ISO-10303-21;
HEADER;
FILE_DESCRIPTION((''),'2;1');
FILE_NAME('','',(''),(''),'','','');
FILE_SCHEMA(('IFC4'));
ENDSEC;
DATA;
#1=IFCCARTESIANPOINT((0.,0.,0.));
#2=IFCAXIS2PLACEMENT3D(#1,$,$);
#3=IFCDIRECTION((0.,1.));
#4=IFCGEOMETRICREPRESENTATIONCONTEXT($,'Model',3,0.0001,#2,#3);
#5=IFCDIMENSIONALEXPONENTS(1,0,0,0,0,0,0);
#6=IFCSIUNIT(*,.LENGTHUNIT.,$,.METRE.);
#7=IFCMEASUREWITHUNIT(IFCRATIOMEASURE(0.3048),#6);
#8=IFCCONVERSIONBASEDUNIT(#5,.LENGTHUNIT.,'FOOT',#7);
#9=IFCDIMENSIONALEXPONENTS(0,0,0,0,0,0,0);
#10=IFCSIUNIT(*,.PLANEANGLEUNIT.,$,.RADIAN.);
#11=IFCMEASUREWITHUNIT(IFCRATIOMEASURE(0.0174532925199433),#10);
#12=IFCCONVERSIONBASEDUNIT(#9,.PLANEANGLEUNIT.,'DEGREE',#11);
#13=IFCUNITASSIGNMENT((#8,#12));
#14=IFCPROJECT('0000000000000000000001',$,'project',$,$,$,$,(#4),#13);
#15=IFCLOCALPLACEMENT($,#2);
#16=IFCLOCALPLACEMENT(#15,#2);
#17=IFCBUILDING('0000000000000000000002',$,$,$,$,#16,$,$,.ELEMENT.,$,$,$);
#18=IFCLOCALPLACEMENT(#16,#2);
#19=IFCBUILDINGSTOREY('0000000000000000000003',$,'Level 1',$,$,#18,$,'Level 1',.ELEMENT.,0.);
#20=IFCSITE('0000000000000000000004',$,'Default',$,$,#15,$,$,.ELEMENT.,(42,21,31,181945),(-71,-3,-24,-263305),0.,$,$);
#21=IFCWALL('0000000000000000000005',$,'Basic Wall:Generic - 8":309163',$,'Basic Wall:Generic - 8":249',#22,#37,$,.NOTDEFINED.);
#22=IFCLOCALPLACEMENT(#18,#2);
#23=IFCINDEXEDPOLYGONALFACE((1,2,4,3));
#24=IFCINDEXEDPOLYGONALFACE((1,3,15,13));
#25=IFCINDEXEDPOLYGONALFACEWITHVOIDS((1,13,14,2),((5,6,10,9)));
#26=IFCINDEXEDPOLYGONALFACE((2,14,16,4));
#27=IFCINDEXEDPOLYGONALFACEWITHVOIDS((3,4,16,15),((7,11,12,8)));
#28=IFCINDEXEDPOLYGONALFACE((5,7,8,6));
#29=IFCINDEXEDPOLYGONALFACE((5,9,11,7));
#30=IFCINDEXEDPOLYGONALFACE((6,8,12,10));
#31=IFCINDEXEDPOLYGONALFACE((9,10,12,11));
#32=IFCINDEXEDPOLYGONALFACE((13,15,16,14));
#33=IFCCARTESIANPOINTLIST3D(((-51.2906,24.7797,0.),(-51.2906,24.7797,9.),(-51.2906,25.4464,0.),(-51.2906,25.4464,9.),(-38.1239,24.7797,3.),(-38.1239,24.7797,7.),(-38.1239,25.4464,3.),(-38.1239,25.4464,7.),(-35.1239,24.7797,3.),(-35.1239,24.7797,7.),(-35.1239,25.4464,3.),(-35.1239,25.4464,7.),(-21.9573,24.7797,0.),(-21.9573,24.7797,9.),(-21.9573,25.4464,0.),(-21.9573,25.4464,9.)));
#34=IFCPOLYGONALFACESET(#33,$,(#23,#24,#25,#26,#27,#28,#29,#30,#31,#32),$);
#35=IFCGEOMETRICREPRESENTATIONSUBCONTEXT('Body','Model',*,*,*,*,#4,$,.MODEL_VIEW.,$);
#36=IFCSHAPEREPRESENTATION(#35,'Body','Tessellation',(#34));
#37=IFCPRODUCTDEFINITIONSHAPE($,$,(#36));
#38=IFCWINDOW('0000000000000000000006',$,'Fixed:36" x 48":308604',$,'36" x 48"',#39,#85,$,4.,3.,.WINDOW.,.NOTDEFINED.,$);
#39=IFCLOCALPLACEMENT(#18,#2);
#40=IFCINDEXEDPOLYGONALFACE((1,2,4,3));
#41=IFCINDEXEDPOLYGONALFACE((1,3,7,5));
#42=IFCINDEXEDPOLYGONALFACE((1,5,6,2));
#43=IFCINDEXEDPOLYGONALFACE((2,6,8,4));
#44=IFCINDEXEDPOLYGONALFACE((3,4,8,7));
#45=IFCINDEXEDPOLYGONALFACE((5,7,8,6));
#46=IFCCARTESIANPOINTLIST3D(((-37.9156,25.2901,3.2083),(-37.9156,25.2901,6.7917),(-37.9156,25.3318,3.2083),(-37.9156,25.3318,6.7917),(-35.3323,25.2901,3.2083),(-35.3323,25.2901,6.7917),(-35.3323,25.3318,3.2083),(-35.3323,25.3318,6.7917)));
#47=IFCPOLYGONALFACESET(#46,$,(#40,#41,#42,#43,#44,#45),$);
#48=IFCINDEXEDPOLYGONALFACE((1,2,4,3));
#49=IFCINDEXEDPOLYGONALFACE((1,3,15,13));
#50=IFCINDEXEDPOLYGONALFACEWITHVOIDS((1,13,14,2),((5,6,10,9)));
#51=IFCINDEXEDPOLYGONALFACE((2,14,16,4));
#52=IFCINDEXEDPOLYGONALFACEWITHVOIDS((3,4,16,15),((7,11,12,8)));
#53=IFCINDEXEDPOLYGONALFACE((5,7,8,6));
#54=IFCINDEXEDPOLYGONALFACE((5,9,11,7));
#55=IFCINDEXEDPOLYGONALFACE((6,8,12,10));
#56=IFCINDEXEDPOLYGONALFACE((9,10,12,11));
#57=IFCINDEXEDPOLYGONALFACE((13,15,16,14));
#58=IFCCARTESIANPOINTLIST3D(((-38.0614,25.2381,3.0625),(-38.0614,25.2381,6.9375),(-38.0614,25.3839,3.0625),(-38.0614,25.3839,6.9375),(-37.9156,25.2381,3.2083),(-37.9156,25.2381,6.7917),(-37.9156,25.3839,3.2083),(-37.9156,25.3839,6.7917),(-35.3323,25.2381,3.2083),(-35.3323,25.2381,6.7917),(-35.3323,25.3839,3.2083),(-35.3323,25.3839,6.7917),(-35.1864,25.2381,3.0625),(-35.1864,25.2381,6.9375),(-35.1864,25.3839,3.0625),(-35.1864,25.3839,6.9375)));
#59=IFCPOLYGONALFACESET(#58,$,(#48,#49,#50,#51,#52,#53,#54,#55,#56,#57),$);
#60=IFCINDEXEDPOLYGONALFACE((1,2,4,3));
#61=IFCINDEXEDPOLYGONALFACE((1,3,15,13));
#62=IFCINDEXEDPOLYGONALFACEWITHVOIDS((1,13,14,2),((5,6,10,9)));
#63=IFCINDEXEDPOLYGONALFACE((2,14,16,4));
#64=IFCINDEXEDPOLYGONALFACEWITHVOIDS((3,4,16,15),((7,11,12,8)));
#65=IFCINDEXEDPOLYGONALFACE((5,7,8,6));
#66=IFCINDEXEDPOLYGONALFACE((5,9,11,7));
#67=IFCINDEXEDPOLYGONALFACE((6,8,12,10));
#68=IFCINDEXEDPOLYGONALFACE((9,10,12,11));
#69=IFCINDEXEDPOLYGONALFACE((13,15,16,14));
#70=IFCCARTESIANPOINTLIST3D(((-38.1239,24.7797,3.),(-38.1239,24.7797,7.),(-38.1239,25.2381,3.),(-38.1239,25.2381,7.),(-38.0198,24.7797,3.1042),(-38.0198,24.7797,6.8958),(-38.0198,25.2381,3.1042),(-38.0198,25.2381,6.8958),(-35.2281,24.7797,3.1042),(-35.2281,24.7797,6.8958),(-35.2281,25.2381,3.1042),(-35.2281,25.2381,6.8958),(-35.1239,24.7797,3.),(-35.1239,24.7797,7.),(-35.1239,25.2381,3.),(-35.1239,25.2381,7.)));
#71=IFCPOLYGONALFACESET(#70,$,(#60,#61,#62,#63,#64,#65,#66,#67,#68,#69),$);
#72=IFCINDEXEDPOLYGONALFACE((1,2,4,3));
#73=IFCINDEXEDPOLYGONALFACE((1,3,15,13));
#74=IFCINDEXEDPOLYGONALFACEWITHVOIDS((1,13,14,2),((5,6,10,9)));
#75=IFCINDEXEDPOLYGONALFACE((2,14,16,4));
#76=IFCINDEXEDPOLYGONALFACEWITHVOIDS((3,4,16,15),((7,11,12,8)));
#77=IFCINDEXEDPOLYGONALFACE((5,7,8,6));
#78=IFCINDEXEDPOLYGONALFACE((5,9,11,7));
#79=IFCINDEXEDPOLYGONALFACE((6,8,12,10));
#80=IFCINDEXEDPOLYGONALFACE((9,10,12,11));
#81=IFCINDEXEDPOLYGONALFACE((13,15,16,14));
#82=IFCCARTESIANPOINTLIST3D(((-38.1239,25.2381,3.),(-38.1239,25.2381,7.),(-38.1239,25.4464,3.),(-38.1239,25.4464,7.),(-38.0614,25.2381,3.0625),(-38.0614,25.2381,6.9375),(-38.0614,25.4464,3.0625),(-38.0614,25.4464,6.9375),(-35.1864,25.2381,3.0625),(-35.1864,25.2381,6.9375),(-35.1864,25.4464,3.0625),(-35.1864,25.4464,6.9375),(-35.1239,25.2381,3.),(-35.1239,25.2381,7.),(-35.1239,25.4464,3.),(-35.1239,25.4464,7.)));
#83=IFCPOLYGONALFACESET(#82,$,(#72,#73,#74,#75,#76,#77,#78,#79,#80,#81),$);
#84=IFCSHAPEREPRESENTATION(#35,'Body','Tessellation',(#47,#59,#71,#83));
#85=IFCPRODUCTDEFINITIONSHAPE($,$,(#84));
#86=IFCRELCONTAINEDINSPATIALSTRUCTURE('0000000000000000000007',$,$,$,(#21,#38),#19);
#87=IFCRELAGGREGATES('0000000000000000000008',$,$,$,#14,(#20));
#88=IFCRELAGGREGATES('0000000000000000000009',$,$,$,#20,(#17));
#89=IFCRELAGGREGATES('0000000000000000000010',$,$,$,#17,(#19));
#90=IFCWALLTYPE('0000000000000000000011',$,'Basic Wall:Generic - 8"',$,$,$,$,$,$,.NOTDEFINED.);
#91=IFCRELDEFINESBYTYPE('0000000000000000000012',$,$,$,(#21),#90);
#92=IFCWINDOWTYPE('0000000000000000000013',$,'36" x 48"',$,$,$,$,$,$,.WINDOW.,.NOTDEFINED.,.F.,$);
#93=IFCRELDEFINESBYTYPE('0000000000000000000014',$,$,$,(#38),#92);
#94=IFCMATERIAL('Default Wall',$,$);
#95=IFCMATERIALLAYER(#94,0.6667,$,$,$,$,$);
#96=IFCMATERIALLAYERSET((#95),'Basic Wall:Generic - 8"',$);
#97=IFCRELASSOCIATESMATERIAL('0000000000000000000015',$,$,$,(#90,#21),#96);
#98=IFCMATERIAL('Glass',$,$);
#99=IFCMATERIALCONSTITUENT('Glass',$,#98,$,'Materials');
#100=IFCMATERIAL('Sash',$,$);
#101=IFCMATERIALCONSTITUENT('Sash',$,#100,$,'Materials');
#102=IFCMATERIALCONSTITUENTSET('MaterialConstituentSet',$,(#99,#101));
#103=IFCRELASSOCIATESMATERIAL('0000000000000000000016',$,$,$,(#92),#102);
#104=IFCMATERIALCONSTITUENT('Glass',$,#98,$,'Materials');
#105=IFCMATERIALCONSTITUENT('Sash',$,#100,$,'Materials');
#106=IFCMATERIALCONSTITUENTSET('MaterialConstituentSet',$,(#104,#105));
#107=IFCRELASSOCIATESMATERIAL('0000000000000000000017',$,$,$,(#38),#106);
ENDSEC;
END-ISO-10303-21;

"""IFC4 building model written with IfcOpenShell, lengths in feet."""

from ifc_helpers import new_model, entity, si_unit, converted_unit, direction, frame, frame_2d, origin, place, context, subcontext, project, spatial, polyline, rectangle, outline, extrude, clip, bounded_halfspace, source, transform, mapped, material, layer, layer_set, layer_usage, constituent, constituent_set, type_object, type_shapes, element, fill, save


model = new_model("IFC4")

# Units and contexts
model_context = context("Model", 3, precision=0.0001, world=origin(), true_north=direction((0.0, 1.0)))
body_context = subcontext(model_context, "Body", "Model", "MODEL_VIEW")
ifc_project = project(units=[converted_unit("LENGTHUNIT", "FOOT", entity("IfcRatioMeasure", 0.3048), si_unit("LENGTHUNIT", "METRE"), dimensions=[1, 0, 0, 0, 0, 0, 0]), converted_unit("PLANEANGLEUNIT", "DEGREE", entity("IfcRatioMeasure", 0.0174532925199433), si_unit("PLANEANGLEUNIT", "RADIAN"), dimensions=[0, 0, 0, 0, 0, 0, 0])], contexts=[model_context])

# Site, building, storey
site_placement = place(None, origin())
site = spatial("IfcSite", under=ifc_project, at=site_placement, Name="Default", CompositionType="ELEMENT", RefLatitude=(42, 21, 31, 181945), RefLongitude=(-71, -3, -24, -263305), RefElevation=0.0)
building_placement = place(site_placement, origin())
building = spatial("IfcBuilding", under=site, at=building_placement, CompositionType="ELEMENT")
storey_placement = place(building_placement, origin())
storey = spatial("IfcBuildingStorey", under=building, at=storey_placement, Name="Level 1", LongName="Level 1", CompositionType="ELEMENT", Elevation=0.0)

# Shared definitions
ifc_material_1 = material(Name="Default Wall")
ifc_layer = layer(ifc_material_1, 0.6667)
ifc_layer_set = layer_set([ifc_layer], Name="Basic Wall:Generic - 8\"")
wall_type = type_object("IfcWallType", Name="Basic Wall:Generic - 8\"", PredefinedType="NOTDEFINED", material=ifc_layer_set)
ifc_material_2 = material(Name="Glass")
ifc_material_3 = material(Name="Sash")
ifc_constituent_1 = constituent(ifc_material_2, Name="Glass", Category="Materials")
ifc_constituent_2 = constituent(ifc_material_3, Name="Sash", Category="Materials")
ifc_constituent_set_1 = constituent_set(constituents=[ifc_constituent_1, ifc_constituent_2], Name="MaterialConstituentSet")
window_type_1 = type_object("IfcWindowType", Name="36\" x 48\"", ParameterTakesPrecedence=False, PartitioningType="NOTDEFINED", PredefinedType="WINDOW", material=ifc_constituent_set_1)
shared_shape_1 = source(origin(), body_context, "Body", "SweptSolid", [
    extrude(rectangle(XDim=0.0417, YDim=2.5833, at=frame_2d((0.0, 0.0), x_axis=(1.0, 0.0))), frame((1.5, 0.5312, 0.2083), z_axis=(0.0, 0.0, 1.0), x_axis=(0.0, 1.0, 0.0)), (0.0, 0.0, 1.0), 3.5833),
    extrude(outline(polyline([(-1.4375, -1.9375), (1.4375, -1.9375), (1.4375, 1.9375), (-1.4375, 1.9375), (-1.4375, -1.9375)]), holes=[polyline([(-1.2917, -1.7917), (-1.2917, 1.7917), (1.2917, 1.7917), (1.2917, -1.7917), (-1.2917, -1.7917)])]), frame((1.5, 0.4583, 2.0), z_axis=(0.0, 1.0, 0.0), x_axis=(1.0, 0.0, 0.0)), (0.0, 0.0, 1.0), 0.1458),
    extrude(outline(polyline([(-1.5, -2.0), (1.5, -2.0), (1.5, 2.0), (-1.5, 2.0), (-1.5, -2.0)]), holes=[polyline([(-1.3958, -1.8958), (-1.3958, 1.8958), (1.3958, 1.8958), (1.3958, -1.8958), (-1.3958, -1.8958)])]), frame((1.5, 0.0, 2.0), z_axis=(0.0, 1.0, 0.0), x_axis=(1.0, 0.0, 0.0)), (0.0, 0.0, 1.0), 0.4583),
    extrude(outline(polyline([(-2.0, -1.5), (2.0, -1.5), (2.0, 1.5), (-2.0, 1.5), (-2.0, -1.5)]), holes=[polyline([(-1.9375, -1.4375), (-1.9375, 1.4375), (1.9375, 1.4375), (1.9375, -1.4375), (-1.9375, -1.4375)])]), frame((1.5, 0.4583, 2.0), z_axis=(0.0, 1.0, 0.0), x_axis=(0.0, 0.0, -1.0)), (0.0, 0.0, 1.0), 0.2083),
])
type_shapes(window_type_1, [shared_shape_1])

# Wall, opening, window
ifc_layer_usage_1 = layer_usage(ifc_layer_set, "AXIS2", "NEGATIVE", 0.3333)
wall_1_placement = place(storey_placement, frame((-51.2906, 25.1131, 0.0)))
wall_1 = element("IfcWall", 1, at=wall_1_placement, inside=storey, type_object=wall_type, material=ifc_layer_usage_1, Name="Basic Wall:Generic - 8\":309163", ObjectType="Basic Wall:Generic - 8\":249", PredefinedType="NOTDEFINED", context=body_context, shape_type="Clipping", body=[
    clip(extrude(rectangle(XDim=29.3333, YDim=0.6667, at=frame_2d((14.6667, 0.0), x_axis=(-1.0, 0.0))), origin(), (0.0, 0.0, 1.0), 9.0), bounded_halfspace(frame((0.0, -0.3333, 9.0), z_axis=(0.0, 0.0, -1.0), x_axis=(1.0, 0.0, 0.0)), True, frame((0.0, -0.3333, 9.0)), polyline([(0.0, 0.0), (29.3333, 0.0), (29.3333, 0.6667), (0.0, 0.6667), (0.0, 0.0)]))),
])
opening_1_placement = place(wall_1_placement, frame((13.1667, -0.3333, 3.0)))
opening_1 = element("IfcOpeningElement", 2, at=opening_1_placement, cuts=wall_1, ObjectType="Opening", PredefinedType="OPENING", context=body_context, shape_type="SweptSolid", body=[
    extrude(rectangle(XDim=4.0, YDim=3.0, at=frame_2d((2.0, 1.5), x_axis=(-1.0, 0.0))), frame((0.0, 0.0, 0.0), z_axis=(0.0, 1.0, 0.0), x_axis=(0.0, 0.0, 1.0)), (0.0, 0.0, 1.0), 0.6667),
])
ifc_constituent_3 = constituent(ifc_material_2, Name="Glass", Category="Materials")
ifc_constituent_4 = constituent(ifc_material_3, Name="Sash", Category="Materials")
ifc_constituent_set_2 = constituent_set(constituents=[ifc_constituent_3, ifc_constituent_4], Name="MaterialConstituentSet")
window_1_placement = place(opening_1_placement, origin())
window_1 = element("IfcWindow", 3, at=window_1_placement, inside=storey, type_object=window_type_1, material=ifc_constituent_set_2, Name="Fixed:36\" x 48\":308604", ObjectType="36\" x 48\"", OverallHeight=4.0, OverallWidth=3.0, PartitioningType="NOTDEFINED", PredefinedType="WINDOW", context=body_context, shape_type="MappedRepresentation", body=[
    mapped(shared_shape_1, transform((0.0, 0.0, 0.0), scale=1.0)),
])
fill(opening_1, window_1)

save(model, "model.ifc")
